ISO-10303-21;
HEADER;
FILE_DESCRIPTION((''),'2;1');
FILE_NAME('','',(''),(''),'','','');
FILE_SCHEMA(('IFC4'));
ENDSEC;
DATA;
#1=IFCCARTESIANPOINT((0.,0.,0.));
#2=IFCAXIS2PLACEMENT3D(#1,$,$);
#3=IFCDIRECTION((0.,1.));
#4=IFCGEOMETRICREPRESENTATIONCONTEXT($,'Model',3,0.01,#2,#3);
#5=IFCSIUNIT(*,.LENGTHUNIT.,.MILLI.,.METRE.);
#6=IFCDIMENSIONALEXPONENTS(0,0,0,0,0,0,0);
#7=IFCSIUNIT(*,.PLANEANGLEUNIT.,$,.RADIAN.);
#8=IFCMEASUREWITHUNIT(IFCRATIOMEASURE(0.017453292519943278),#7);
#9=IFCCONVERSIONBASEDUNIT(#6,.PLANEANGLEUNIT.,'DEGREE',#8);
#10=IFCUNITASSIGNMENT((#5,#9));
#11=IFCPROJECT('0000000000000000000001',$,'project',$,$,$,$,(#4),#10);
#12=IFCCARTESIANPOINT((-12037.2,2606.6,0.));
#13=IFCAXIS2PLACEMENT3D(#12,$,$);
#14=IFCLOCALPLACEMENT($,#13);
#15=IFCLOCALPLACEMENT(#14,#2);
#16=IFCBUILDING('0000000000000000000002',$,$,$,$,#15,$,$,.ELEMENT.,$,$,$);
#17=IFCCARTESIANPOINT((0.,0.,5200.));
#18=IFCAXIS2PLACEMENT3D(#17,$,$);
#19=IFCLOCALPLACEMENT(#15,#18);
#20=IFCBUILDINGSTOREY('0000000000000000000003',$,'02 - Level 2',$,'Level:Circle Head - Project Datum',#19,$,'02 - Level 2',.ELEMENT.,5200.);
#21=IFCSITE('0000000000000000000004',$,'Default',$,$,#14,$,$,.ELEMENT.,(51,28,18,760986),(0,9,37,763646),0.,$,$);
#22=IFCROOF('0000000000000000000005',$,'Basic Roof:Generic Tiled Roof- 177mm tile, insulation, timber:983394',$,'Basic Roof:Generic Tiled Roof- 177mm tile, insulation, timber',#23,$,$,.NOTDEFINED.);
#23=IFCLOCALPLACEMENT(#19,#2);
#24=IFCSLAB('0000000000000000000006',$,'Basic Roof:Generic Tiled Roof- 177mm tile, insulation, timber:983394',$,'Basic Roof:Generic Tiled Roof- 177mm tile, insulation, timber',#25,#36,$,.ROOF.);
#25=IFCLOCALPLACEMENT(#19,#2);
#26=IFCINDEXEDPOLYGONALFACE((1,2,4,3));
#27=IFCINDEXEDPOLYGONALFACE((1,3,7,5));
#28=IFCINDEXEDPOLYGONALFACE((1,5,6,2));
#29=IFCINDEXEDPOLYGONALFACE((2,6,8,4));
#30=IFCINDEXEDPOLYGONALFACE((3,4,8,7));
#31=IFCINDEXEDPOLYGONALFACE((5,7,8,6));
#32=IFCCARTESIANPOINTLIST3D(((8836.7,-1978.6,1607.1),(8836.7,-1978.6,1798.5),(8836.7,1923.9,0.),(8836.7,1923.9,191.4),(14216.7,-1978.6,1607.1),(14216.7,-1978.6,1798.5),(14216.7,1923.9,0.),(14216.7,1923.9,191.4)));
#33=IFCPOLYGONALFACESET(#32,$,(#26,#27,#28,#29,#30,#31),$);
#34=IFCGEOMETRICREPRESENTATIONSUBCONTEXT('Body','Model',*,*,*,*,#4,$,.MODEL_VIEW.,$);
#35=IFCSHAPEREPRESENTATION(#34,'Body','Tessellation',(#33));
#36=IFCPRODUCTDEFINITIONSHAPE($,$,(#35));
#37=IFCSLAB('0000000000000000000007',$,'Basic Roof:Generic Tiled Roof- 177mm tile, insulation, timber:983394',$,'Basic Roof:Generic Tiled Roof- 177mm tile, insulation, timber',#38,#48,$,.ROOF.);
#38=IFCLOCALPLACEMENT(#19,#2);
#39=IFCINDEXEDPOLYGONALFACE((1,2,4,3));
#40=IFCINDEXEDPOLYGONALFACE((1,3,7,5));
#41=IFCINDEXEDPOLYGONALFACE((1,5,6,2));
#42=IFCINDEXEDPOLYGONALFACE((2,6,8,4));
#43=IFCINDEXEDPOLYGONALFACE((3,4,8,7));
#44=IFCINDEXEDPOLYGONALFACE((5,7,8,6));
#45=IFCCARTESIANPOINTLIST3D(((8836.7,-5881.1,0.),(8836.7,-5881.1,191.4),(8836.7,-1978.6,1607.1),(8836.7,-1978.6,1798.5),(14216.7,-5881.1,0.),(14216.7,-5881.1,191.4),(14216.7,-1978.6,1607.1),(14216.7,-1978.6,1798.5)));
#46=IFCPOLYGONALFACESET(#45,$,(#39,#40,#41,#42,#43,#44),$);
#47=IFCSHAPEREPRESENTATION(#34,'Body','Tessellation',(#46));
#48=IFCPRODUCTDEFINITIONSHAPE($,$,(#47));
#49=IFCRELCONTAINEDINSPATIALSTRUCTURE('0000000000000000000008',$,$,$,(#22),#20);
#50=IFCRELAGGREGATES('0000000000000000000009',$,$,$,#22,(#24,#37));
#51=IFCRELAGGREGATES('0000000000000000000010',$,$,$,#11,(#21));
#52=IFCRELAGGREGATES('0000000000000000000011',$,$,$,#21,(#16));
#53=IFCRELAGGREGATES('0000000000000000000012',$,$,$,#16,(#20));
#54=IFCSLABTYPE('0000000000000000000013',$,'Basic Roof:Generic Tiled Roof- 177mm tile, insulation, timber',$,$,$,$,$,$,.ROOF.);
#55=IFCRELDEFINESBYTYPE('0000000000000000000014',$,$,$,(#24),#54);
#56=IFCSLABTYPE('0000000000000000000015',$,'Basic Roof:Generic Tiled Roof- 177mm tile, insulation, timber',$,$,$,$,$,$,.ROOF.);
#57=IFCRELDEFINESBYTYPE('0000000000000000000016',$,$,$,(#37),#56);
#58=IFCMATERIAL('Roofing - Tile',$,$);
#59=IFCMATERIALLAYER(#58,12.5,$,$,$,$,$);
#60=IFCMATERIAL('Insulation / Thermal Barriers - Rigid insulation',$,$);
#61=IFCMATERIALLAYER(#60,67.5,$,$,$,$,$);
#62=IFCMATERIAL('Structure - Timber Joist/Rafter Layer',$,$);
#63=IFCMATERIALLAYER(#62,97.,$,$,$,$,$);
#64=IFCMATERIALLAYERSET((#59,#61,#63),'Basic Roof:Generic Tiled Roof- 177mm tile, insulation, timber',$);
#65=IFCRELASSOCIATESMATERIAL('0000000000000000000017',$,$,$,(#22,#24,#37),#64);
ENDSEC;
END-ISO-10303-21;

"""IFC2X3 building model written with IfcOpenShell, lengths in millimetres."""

from ifc_helpers import new_model, entity, si_unit, converted_unit, direction, frame, frame_2d, origin, place, context, subcontext, project, spatial, rectangle, extrude, material, layer, layer_set, type_object, element, aggregate, save


model = new_model("IFC2X3")

# Units and contexts
model_context = context("Model", 3, precision=0.01, world=origin(), true_north=direction((0.0, 1.0)))
body_context = subcontext(model_context, "Body", "Model", "MODEL_VIEW")
ifc_project = project(units=[si_unit("LENGTHUNIT", "METRE", prefix="MILLI"), converted_unit("PLANEANGLEUNIT", "DEGREE", entity("IfcRatioMeasure", 0.017453292519943278), si_unit("PLANEANGLEUNIT", "RADIAN"), dimensions=[0, 0, 0, 0, 0, 0, 0])], contexts=[model_context])

# Site, building, storey
site_placement = place(None, frame((-12037.2, 2606.6, 0.0)))
site = spatial("IfcSite", under=ifc_project, at=site_placement, Name="Default", CompositionType="ELEMENT", RefLatitude=(51, 28, 18, 760986), RefLongitude=(0, 9, 37, 763646), RefElevation=0.0)
building_placement = place(site_placement, origin())
building = spatial("IfcBuilding", under=site, at=building_placement, CompositionType="ELEMENT")
storey_placement = place(building_placement, frame((0.0, 0.0, 5200.0)))
storey = spatial("IfcBuildingStorey", under=building, at=storey_placement, Name="02 - Level 2", ObjectType="Level:Circle Head - Project Datum", LongName="02 - Level 2", CompositionType="ELEMENT", Elevation=5200.0)

# Roof, slabs
ifc_material_1 = material(Name="Roofing - Tile")
ifc_layer_1 = layer(ifc_material_1, 12.5)
ifc_material_2 = material(Name="Insulation / Thermal Barriers - Rigid insulation")
ifc_layer_2 = layer(ifc_material_2, 67.5)
ifc_material_3 = material(Name="Structure - Timber Joist/Rafter Layer")
ifc_layer_3 = layer(ifc_material_3, 97.0)
ifc_layer_set_1 = layer_set([ifc_layer_1, ifc_layer_2, ifc_layer_3], Name="Basic Roof:Generic Tiled Roof- 177mm tile, insulation, timber")
roof_placement = place(storey_placement, frame((8836.7, -5881.1, 0.0)))
roof = element("IfcRoof", 1, at=roof_placement, inside=storey, material=ifc_layer_set_1, Name="Basic Roof:Generic Tiled Roof- 177mm tile, insulation, timber:983394", ObjectType="Basic Roof:Generic Tiled Roof- 177mm tile, insulation, timber", ShapeType="NOTDEFINED")
slab_type_1 = type_object("IfcSlabType", Name="Basic Roof:Generic Tiled Roof- 177mm tile, insulation, timber", PredefinedType="ROOF")
slab_1_placement = place(roof_placement, origin())
slab_1 = element("IfcSlab", 2, at=slab_1_placement, type_object=slab_type_1, material=ifc_layer_set_1, Name="Basic Roof:Generic Tiled Roof- 177mm tile, insulation, timber:983394", ObjectType="Basic Roof:Generic Tiled Roof- 177mm tile, insulation, timber", PredefinedType="ROOF", context=body_context, shape_type="SweptSolid", body=[
    extrude(rectangle(XDim=4220.4, YDim=5380.0, at=frame_2d((0.0, 0.0), x_axis=(0.0, -1.0))), frame((2690.0, 5853.7, 803.5), z_axis=(0.0, 0.380778, 0.924666), x_axis=(1.0, 0.0, 0.0)), (0.0, -0.380778, 0.924666), 191.4),
])
slab_type_2 = type_object("IfcSlabType", Name="Basic Roof:Generic Tiled Roof- 177mm tile, insulation, timber", PredefinedType="ROOF")
slab_2_placement = place(roof_placement, origin())
slab_2 = element("IfcSlab", 3, at=slab_2_placement, type_object=slab_type_2, material=ifc_layer_set_1, Name="Basic Roof:Generic Tiled Roof- 177mm tile, insulation, timber:983394", ObjectType="Basic Roof:Generic Tiled Roof- 177mm tile, insulation, timber", PredefinedType="ROOF", context=body_context, shape_type="SweptSolid", body=[
    extrude(rectangle(XDim=5380.0, YDim=4220.4, at=frame_2d((0.0, 0.0), x_axis=(-1.0, 0.0))), frame((2690.0, 1951.2, 803.5), z_axis=(0.0, -0.380778, 0.924666), x_axis=(1.0, 0.0, 0.0)), (0.0, 0.380778, 0.924666), 191.4),
])
aggregate(roof, [slab_1, slab_2])

save(model, "model.ifc")
